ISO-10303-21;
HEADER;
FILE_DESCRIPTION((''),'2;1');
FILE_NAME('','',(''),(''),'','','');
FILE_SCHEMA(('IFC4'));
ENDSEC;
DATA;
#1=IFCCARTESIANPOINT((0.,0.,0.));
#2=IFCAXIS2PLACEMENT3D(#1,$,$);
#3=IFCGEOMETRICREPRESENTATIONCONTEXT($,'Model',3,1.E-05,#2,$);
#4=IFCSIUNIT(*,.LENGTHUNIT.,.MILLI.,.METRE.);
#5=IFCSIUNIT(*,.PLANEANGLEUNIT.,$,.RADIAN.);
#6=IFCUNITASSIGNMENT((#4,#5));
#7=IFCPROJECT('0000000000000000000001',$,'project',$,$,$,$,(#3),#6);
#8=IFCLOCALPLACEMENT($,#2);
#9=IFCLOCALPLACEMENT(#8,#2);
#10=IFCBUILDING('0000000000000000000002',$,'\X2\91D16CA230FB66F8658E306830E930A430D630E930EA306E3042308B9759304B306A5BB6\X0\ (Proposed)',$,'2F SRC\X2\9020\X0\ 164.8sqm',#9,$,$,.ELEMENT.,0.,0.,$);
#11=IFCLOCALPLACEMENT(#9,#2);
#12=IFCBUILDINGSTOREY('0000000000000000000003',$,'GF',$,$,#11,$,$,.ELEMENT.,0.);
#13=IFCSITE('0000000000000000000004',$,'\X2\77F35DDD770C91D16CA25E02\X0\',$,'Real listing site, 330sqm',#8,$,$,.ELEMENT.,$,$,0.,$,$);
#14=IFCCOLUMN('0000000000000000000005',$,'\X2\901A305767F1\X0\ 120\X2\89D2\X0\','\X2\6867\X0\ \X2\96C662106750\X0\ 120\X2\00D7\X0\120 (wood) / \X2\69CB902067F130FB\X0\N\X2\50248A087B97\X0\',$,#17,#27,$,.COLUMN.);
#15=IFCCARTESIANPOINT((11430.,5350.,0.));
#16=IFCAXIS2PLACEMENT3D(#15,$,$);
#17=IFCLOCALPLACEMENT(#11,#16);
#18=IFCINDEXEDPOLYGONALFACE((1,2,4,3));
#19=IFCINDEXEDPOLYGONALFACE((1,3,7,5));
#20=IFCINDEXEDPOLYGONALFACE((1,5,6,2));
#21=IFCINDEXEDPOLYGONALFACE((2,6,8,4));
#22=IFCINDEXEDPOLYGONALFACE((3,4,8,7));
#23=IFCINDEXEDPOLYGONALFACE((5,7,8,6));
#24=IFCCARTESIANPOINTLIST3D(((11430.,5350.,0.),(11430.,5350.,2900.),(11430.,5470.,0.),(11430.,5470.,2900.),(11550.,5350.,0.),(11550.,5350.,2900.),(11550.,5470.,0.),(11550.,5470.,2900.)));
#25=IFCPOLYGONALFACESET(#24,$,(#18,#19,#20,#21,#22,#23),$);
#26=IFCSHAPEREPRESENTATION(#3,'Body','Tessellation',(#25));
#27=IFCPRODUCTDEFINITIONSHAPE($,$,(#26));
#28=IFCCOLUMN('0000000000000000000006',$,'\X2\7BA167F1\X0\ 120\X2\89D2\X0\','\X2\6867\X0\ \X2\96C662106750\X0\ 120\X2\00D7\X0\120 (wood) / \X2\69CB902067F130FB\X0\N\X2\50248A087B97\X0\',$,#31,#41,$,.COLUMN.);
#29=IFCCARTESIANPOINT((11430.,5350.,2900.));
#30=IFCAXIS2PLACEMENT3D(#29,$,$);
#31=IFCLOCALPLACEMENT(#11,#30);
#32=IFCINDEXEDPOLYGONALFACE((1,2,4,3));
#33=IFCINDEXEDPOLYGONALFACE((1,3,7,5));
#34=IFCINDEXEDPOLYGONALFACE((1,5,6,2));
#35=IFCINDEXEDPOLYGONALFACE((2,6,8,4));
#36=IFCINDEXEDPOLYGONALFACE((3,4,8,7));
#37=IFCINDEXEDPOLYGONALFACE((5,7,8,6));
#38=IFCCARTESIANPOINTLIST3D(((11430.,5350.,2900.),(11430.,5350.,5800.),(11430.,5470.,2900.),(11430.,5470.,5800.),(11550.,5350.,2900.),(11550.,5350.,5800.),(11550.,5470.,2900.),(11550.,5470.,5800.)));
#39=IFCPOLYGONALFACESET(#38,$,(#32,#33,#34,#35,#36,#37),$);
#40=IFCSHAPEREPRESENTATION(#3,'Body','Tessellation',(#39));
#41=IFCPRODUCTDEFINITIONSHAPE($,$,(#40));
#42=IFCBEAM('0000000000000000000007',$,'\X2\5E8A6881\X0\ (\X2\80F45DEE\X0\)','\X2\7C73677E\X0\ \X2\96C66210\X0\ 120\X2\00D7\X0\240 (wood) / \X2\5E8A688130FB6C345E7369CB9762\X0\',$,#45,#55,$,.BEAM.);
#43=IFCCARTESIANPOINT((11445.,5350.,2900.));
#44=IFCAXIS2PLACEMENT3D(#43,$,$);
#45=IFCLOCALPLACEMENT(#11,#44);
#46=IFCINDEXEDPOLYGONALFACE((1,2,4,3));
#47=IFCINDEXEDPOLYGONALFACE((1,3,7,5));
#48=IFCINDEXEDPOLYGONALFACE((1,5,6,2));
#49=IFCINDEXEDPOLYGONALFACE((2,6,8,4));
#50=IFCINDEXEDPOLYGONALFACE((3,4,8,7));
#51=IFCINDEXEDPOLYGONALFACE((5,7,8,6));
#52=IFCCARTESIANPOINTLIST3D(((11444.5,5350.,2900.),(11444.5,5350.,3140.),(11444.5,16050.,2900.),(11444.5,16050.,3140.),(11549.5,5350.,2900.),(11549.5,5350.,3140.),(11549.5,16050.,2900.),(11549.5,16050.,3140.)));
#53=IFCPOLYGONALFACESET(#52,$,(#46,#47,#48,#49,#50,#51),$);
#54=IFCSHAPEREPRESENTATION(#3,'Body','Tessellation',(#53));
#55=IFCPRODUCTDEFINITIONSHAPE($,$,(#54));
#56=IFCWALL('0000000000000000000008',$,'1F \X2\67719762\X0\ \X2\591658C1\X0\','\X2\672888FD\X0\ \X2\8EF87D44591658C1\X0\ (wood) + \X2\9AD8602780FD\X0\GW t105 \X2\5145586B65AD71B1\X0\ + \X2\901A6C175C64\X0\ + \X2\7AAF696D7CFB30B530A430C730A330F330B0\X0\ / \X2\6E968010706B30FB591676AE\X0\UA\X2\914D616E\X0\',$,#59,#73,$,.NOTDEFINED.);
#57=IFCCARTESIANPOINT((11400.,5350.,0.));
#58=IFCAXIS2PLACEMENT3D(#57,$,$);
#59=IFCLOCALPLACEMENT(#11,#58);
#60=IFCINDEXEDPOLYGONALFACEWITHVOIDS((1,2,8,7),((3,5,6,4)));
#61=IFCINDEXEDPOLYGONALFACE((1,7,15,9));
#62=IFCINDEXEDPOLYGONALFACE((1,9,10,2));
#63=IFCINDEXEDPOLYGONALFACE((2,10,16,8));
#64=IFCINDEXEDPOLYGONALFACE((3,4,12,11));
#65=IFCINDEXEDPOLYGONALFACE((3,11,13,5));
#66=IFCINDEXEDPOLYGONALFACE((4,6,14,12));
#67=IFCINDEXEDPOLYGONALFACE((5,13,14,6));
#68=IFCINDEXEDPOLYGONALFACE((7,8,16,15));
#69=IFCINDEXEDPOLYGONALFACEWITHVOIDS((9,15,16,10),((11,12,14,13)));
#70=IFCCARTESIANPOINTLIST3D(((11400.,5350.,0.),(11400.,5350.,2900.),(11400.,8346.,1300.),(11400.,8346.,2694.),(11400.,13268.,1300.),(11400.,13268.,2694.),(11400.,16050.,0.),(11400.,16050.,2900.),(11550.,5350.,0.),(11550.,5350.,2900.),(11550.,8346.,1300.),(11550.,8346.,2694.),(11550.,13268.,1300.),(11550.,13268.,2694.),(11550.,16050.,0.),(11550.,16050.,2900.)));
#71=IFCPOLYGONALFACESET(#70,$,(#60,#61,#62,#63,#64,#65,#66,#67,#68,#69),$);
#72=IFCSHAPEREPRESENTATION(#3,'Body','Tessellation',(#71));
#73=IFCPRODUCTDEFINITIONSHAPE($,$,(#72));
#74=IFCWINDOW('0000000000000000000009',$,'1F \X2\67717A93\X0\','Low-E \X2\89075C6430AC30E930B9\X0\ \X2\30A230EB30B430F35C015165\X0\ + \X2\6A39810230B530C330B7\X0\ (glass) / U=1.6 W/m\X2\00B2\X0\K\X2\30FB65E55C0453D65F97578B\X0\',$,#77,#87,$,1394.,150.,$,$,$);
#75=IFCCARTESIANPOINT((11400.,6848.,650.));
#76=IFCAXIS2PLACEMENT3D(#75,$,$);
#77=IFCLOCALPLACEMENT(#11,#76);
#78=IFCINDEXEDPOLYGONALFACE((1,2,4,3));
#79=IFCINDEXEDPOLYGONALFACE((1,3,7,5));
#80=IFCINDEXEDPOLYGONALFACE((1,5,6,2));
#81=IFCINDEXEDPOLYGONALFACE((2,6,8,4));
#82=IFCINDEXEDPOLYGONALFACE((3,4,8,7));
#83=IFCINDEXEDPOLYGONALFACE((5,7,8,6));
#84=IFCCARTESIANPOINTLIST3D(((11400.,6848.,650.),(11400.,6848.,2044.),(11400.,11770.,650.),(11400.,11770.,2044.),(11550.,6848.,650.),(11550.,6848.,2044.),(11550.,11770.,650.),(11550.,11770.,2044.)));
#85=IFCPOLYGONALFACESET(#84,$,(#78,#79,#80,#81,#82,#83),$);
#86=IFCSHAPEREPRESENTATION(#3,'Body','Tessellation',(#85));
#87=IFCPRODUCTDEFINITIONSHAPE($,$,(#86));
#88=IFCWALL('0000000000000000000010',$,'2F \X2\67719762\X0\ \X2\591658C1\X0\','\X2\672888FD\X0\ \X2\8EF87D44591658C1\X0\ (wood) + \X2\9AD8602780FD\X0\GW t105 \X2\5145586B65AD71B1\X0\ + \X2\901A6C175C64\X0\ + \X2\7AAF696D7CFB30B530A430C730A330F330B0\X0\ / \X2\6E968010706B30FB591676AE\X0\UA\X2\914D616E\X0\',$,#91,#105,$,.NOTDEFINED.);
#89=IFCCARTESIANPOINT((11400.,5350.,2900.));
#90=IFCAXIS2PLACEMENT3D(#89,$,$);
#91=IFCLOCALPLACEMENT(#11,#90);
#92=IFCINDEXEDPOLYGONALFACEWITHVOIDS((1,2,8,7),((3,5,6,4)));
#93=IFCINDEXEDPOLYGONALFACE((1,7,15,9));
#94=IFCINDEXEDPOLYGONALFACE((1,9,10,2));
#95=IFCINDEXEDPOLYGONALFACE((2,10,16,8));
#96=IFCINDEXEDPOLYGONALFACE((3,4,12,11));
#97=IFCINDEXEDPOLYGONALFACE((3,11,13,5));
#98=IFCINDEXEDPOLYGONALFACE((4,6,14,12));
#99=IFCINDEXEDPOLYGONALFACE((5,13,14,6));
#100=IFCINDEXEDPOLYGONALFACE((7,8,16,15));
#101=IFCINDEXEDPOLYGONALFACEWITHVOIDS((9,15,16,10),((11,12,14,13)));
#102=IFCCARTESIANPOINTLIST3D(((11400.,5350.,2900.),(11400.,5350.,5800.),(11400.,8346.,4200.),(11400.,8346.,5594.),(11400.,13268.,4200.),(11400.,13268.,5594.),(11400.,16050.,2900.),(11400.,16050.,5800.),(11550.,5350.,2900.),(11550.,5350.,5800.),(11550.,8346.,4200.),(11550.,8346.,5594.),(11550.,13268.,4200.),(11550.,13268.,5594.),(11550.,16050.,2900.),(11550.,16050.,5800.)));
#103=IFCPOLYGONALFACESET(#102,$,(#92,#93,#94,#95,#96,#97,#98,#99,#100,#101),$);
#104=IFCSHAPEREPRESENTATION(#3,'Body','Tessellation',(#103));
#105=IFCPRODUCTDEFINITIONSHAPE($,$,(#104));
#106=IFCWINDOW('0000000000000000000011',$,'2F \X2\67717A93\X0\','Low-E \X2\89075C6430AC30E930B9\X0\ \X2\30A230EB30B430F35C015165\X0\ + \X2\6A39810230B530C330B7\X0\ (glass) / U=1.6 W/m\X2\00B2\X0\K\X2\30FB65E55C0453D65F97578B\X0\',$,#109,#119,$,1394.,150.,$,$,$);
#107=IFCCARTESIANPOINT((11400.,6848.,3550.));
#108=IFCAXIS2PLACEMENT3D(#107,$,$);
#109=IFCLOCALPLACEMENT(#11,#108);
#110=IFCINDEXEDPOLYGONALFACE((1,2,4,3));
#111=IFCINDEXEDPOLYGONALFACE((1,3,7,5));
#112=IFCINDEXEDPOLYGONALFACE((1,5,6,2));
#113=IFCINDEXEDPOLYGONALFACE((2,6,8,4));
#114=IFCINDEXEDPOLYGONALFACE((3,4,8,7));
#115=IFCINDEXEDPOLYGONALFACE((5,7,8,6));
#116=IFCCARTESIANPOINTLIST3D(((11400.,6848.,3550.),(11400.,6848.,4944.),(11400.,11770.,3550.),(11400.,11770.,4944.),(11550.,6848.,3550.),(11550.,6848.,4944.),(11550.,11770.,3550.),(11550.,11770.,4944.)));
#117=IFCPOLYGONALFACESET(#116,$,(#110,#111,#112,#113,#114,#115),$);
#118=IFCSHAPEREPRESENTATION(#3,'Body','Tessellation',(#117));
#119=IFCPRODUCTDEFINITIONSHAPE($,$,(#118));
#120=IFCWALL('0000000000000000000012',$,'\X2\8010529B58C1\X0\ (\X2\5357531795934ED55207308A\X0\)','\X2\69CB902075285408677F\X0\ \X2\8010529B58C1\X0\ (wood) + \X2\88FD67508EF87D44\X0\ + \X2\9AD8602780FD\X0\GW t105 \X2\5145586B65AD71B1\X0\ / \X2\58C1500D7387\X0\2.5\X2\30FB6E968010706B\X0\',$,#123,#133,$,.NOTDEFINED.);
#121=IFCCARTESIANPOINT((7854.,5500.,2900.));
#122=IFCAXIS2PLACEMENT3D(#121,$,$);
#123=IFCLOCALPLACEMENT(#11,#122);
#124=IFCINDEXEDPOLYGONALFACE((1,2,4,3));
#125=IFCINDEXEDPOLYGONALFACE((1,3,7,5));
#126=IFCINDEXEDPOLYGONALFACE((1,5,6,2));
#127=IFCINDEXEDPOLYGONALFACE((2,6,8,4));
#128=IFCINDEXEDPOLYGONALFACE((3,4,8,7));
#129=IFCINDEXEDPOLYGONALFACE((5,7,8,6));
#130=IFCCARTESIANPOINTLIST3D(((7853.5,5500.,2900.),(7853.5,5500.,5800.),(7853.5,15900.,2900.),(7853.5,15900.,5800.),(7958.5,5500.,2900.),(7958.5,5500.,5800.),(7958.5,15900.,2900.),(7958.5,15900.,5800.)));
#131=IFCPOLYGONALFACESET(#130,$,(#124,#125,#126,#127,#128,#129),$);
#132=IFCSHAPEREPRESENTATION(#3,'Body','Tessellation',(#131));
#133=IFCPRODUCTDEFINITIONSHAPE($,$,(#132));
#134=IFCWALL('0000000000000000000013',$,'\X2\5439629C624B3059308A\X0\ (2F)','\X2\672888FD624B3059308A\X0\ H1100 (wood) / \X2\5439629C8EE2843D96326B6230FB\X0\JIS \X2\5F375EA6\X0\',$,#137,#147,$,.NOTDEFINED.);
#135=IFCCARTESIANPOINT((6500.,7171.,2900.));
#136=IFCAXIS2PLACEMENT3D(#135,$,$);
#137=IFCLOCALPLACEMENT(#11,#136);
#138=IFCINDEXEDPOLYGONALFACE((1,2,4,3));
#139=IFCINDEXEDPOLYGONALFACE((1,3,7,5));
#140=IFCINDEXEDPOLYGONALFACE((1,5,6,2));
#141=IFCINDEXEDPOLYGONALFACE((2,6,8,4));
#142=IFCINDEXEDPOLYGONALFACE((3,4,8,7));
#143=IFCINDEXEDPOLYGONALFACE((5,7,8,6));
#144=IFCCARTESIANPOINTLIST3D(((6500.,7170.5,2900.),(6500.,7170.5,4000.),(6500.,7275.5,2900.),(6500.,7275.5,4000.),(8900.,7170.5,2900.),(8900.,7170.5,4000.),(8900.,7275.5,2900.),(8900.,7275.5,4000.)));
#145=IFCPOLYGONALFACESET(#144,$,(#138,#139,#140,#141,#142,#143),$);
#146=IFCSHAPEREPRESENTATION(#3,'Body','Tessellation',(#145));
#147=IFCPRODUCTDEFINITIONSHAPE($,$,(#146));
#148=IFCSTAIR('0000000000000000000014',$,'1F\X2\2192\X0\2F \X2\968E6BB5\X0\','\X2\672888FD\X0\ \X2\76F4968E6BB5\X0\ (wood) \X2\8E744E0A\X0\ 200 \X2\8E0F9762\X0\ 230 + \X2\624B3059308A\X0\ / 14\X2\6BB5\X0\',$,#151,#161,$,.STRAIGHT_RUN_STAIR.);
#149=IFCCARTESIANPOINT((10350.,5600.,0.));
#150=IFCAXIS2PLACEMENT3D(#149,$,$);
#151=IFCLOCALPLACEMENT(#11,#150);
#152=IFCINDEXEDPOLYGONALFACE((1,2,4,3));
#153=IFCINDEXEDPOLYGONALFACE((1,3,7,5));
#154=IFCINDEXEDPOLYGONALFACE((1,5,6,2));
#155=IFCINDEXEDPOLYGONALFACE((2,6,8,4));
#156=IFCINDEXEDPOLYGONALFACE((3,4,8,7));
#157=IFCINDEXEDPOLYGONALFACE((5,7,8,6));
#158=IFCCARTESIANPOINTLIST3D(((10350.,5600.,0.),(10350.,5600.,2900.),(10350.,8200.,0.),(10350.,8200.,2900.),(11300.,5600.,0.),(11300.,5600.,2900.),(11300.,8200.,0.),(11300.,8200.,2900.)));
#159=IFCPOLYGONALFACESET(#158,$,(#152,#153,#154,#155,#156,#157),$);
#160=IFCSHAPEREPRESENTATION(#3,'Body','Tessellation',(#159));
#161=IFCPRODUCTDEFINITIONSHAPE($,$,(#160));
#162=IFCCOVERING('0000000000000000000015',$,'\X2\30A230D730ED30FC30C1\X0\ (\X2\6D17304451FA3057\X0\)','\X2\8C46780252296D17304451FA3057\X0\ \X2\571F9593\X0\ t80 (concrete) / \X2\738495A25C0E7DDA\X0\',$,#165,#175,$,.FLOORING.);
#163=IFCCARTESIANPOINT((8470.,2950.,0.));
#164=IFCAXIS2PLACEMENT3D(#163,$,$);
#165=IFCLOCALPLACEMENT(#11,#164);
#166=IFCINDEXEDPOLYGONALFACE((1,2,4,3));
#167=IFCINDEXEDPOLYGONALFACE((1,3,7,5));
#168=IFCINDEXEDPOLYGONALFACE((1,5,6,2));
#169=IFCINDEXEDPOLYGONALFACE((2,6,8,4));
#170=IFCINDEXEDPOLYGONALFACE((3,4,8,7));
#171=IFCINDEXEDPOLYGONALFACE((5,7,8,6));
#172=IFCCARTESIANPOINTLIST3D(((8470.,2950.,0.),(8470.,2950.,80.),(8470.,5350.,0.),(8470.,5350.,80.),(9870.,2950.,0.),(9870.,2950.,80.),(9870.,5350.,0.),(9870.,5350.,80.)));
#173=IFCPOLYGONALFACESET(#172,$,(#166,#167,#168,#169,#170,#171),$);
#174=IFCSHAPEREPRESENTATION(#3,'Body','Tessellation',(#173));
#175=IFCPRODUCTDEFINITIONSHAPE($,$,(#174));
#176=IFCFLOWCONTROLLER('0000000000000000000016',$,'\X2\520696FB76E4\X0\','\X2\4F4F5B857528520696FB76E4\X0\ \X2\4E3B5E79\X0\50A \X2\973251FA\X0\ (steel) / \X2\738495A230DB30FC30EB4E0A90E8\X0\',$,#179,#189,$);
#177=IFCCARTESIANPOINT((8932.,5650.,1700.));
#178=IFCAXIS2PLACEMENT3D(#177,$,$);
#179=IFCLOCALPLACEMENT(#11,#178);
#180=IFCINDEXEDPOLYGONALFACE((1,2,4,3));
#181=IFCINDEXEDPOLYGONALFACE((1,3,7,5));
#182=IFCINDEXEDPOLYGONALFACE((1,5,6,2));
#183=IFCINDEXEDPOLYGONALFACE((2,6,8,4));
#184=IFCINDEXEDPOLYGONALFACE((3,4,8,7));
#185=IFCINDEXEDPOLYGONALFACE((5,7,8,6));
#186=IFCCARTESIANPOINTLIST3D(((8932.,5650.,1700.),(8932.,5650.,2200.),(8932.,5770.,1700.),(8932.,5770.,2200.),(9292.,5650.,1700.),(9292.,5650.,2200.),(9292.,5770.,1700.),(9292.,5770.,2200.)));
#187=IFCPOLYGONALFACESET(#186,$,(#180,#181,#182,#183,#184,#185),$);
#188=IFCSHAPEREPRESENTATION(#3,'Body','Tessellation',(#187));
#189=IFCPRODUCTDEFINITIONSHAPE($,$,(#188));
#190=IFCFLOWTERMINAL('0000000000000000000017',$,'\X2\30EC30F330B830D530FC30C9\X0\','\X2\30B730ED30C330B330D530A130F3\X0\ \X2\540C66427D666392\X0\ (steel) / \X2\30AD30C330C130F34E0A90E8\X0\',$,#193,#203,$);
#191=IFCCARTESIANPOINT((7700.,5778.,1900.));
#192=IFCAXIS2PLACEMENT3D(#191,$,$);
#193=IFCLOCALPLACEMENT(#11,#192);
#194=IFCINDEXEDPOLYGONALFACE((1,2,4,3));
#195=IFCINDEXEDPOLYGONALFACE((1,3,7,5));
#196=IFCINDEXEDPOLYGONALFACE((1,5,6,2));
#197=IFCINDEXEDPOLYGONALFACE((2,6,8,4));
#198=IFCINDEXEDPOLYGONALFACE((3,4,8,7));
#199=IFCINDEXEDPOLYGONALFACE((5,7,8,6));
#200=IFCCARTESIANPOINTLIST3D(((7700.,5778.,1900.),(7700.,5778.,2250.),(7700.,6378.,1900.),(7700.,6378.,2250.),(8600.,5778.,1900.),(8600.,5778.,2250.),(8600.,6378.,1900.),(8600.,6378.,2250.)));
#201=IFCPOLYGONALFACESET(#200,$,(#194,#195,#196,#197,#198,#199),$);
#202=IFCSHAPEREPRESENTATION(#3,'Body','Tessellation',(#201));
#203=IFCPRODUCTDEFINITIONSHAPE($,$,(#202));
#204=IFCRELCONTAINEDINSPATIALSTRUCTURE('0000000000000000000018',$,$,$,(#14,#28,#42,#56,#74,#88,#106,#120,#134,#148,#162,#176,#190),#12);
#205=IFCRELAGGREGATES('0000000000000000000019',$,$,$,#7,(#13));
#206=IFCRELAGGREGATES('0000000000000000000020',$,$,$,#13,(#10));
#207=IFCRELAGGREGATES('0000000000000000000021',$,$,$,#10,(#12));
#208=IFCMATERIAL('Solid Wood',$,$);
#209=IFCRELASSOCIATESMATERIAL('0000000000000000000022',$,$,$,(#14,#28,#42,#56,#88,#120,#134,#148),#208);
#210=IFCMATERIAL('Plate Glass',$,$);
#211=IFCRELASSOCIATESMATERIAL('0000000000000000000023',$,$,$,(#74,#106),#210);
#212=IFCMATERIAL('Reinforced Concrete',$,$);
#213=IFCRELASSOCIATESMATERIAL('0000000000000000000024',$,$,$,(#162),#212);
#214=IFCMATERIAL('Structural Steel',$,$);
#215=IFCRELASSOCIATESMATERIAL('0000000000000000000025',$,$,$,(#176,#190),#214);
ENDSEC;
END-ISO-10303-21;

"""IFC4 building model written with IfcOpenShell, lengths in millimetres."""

from ifc_helpers import new_model, si_unit, frame, frame_2d, origin, place, context, project, spatial, rectangle, extrude, material, element, fill, save


model = new_model("IFC4")

# Units and contexts
model_context = context("Model", 3, precision=1e-05, world=origin())
ifc_project = project(units=[si_unit("LENGTHUNIT", "METRE", prefix="MILLI"), si_unit("PLANEANGLEUNIT", "RADIAN")], contexts=[model_context])

# Site, building, storey
site_placement = place(None, origin())
site = spatial("IfcSite", under=ifc_project, at=site_placement, Name="石川県金沢市", ObjectType="Real listing site, 330sqm", CompositionType="ELEMENT", RefElevation=0.0)
building_placement = place(site_placement, origin())
building = spatial("IfcBuilding", under=site, at=building_placement, Name="金沢・書斎とライブラリのある静かな家 (Proposed)", ObjectType="2F SRC造 164.8sqm", CompositionType="ELEMENT", ElevationOfRefHeight=0.0, ElevationOfTerrain=0.0)
storey_placement = place(building_placement, origin())
storey = spatial("IfcBuildingStorey", under=building, at=storey_placement, Name="GF", CompositionType="ELEMENT", Elevation=0.0)

# Columns
ifc_material_1 = material(Name="Solid Wood")
column_1_placement = place(storey_placement, frame((11430.0, 5350.0, 0.0)))
element("IfcColumn", 1, at=column_1_placement, inside=storey, material=ifc_material_1, Name="通し柱 120角", Description="桧 集成材 120×120 (wood) / 構造柱・N値計算", PredefinedType="COLUMN", context=model_context, shape_type="SweptSolid", body=[
    extrude(rectangle(XDim=120.0, YDim=120.0, at=frame_2d((60.0, 60.0))), frame((11430.0, 5350.0, 0.0)), (0.0, 0.0, 1.0), 2900.0),
])
column_2_placement = place(storey_placement, frame((11430.0, 5350.0, 2900.0)))
element("IfcColumn", 2, at=column_2_placement, inside=storey, material=ifc_material_1, Name="管柱 120角", Description="桧 集成材 120×120 (wood) / 構造柱・N値計算", PredefinedType="COLUMN", context=model_context, shape_type="SweptSolid", body=[
    extrude(rectangle(XDim=120.0, YDim=120.0, at=frame_2d((60.0, 60.0))), frame((11430.0, 5350.0, 2900.0)), (0.0, 0.0, 1.0), 2900.0),
])

# Beam
beam_1_placement = place(storey_placement, frame((11445.0, 5350.0, 2900.0)))
element("IfcBeam", 3, at=beam_1_placement, inside=storey, material=ifc_material_1, Name="床梁 (胴差)", Description="米松 集成 120×240 (wood) / 床梁・水平構面", PredefinedType="BEAM", context=model_context, shape_type="SweptSolid", body=[
    extrude(rectangle(XDim=105.0, YDim=10700.0, at=frame_2d((52.0, 5350.0))), frame((11445.0, 5350.0, 2900.0)), (0.0, 0.0, 1.0), 240.0),
])

# Wall, opening, window
wall_1_placement = place(storey_placement, frame((11400.0, 5350.0, 0.0)))
wall_1 = element("IfcWall", 4, at=wall_1_placement, inside=storey, material=ifc_material_1, Name="1F 東面 外壁", Description="木製 軸組外壁 (wood) + 高性能GW t105 充填断熱 + 通気層 + 窯業系サイディング / 準耐火・外皮UA配慮", PredefinedType="NOTDEFINED", context=model_context, shape_type="SweptSolid", body=[
    extrude(rectangle(XDim=150.0, YDim=10700.0, at=frame_2d((75.0, 5350.0))), frame((11400.0, 5350.0, 0.0)), (0.0, 0.0, 1.0), 2900.0),
])
opening_1_placement = place(storey_placement, frame((11400.0, 6848.0, 650.0)))
opening_1 = element("IfcOpeningElement", 5, at=opening_1_placement, cuts=wall_1, PredefinedType="NOTDEFINED", context=model_context, shape_type="SweptSolid", body=[
    extrude(rectangle(XDim=150.0, YDim=4922.0, at=frame_2d((75.0, 2461.0))), frame((11400.0, 6848.0, 650.0)), (0.0, 0.0, 1.0), 1394.0),
])
ifc_material_2 = material(Name="Plate Glass")
window_1_placement = place(storey_placement, frame((11400.0, 6848.0, 650.0)))
window_1 = element("IfcWindow", 6, at=window_1_placement, inside=storey, material=ifc_material_2, Name="1F 東窓", Description="Low-E 複層ガラス アルゴン封入 + 樹脂サッシ (glass) / U=1.6 W/m²K・日射取得型", OverallHeight=1394.0, OverallWidth=150.0, context=model_context, shape_type="SweptSolid", body=[
    extrude(rectangle(XDim=150.0, YDim=4922.0, at=frame_2d((75.0, 2461.0))), frame((11400.0, 6848.0, 650.0)), (0.0, 0.0, 1.0), 1394.0),
])
fill(opening_1, window_1)

# Wall, opening, window
wall_2_placement = place(storey_placement, frame((11400.0, 5350.0, 2900.0)))
wall_2 = element("IfcWall", 7, at=wall_2_placement, inside=storey, material=ifc_material_1, Name="2F 東面 外壁", Description="木製 軸組外壁 (wood) + 高性能GW t105 充填断熱 + 通気層 + 窯業系サイディング / 準耐火・外皮UA配慮", PredefinedType="NOTDEFINED", context=model_context, shape_type="SweptSolid", body=[
    extrude(rectangle(XDim=150.0, YDim=10700.0, at=frame_2d((75.0, 5350.0))), frame((11400.0, 5350.0, 2900.0)), (0.0, 0.0, 1.0), 2900.0),
])
opening_2_placement = place(storey_placement, frame((11400.0, 6848.0, 3550.0)))
opening_2 = element("IfcOpeningElement", 8, at=opening_2_placement, cuts=wall_2, PredefinedType="NOTDEFINED", context=model_context, shape_type="SweptSolid", body=[
    extrude(rectangle(XDim=150.0, YDim=4922.0, at=frame_2d((75.0, 2461.0))), frame((11400.0, 6848.0, 3550.0)), (0.0, 0.0, 1.0), 1394.0),
])
window_2_placement = place(storey_placement, frame((11400.0, 6848.0, 3550.0)))
window_2 = element("IfcWindow", 9, at=window_2_placement, inside=storey, material=ifc_material_2, Name="2F 東窓", Description="Low-E 複層ガラス アルゴン封入 + 樹脂サッシ (glass) / U=1.6 W/m²K・日射取得型", OverallHeight=1394.0, OverallWidth=150.0, context=model_context, shape_type="SweptSolid", body=[
    extrude(rectangle(XDim=150.0, YDim=4922.0, at=frame_2d((75.0, 2461.0))), frame((11400.0, 6848.0, 3550.0)), (0.0, 0.0, 1.0), 1394.0),
])
fill(opening_2, window_2)

# Walls
wall_3_placement = place(storey_placement, frame((7854.0, 5500.0, 2900.0)))
element("IfcWall", 10, at=wall_3_placement, inside=storey, material=ifc_material_1, Name="耐力壁 (南北間仕切り)", Description="構造用合板 耐力壁 (wood) + 製材軸組 + 高性能GW t105 充填断熱 / 壁倍率2.5・準耐火", PredefinedType="NOTDEFINED", context=model_context, shape_type="SweptSolid", body=[
    extrude(rectangle(XDim=105.0, YDim=10400.0, at=frame_2d((52.0, 5200.0))), frame((7854.0, 5500.0, 2900.0)), (0.0, 0.0, 1.0), 2900.0),
])
wall_4_placement = place(storey_placement, frame((6500.0, 7171.0, 2900.0)))
element("IfcWall", 11, at=wall_4_placement, inside=storey, material=ifc_material_1, Name="吹抜手すり (2F)", Description="木製手すり H1100 (wood) / 吹抜転落防止・JIS 強度", PredefinedType="NOTDEFINED", context=model_context, shape_type="SweptSolid", body=[
    extrude(rectangle(XDim=2400.0, YDim=105.0, at=frame_2d((1200.0, 52.0))), frame((6500.0, 7171.0, 2900.0)), (0.0, 0.0, 1.0), 1100.0),
])

# Stair
stair_placement = place(storey_placement, frame((10350.0, 5600.0, 0.0)))
element("IfcStair", 12, at=stair_placement, inside=storey, material=ifc_material_1, Name="1F→2F 階段", Description="木製 直階段 (wood) 蹴上 200 踏面 230 + 手すり / 14段", PredefinedType="STRAIGHT_RUN_STAIR", context=model_context, shape_type="SweptSolid", body=[
    extrude(rectangle(XDim=950.0, YDim=2600.0, at=frame_2d((475.0, 1300.0))), frame((10350.0, 5600.0, 0.0)), (0.0, 0.0, 1.0), 2900.0),
])

# Covering
ifc_material_3 = material(Name="Reinforced Concrete")
covering_placement = place(storey_placement, frame((8470.0, 2950.0, 0.0)))
element("IfcCovering", 13, at=covering_placement, inside=storey, material=ifc_material_3, Name="アプローチ (洗い出し)", Description="豆砂利洗い出し 土間 t80 (concrete) / 玄関導線", PredefinedType="FLOORING", context=model_context, shape_type="SweptSolid", body=[
    extrude(rectangle(XDim=1400.0, YDim=2400.0, at=frame_2d((700.0, 1200.0))), frame((8470.0, 2950.0, 0.0)), (0.0, 0.0, 1.0), 80.0),
])

# Flow controller
ifc_material_4 = material(Name="Structural Steel")
flow_controller_placement = place(storey_placement, frame((8932.0, 5650.0, 1700.0)))
element("IfcFlowController", 14, at=flow_controller_placement, inside=storey, material=ifc_material_4, Name="分電盤", Description="住宅用分電盤 主幹50A 露出 (steel) / 玄関ホール上部", context=model_context, shape_type="SweptSolid", body=[
    extrude(rectangle(XDim=360.0, YDim=120.0, at=frame_2d((180.0, 60.0))), frame((8932.0, 5650.0, 1700.0)), (0.0, 0.0, 1.0), 500.0),
])

# Flow terminal
flow_terminal_1_placement = place(storey_placement, frame((7700.0, 5778.0, 1900.0)))
element("IfcFlowTerminal", 15, at=flow_terminal_1_placement, inside=storey, material=ifc_material_4, Name="レンジフード", Description="シロッコファン 同時給排 (steel) / キッチン上部", context=model_context, shape_type="SweptSolid", body=[
    extrude(rectangle(XDim=900.0, YDim=600.0, at=frame_2d((450.0, 300.0))), frame((7700.0, 5778.0, 1900.0)), (0.0, 0.0, 1.0), 350.0),
])

save(model, "model.ifc")
